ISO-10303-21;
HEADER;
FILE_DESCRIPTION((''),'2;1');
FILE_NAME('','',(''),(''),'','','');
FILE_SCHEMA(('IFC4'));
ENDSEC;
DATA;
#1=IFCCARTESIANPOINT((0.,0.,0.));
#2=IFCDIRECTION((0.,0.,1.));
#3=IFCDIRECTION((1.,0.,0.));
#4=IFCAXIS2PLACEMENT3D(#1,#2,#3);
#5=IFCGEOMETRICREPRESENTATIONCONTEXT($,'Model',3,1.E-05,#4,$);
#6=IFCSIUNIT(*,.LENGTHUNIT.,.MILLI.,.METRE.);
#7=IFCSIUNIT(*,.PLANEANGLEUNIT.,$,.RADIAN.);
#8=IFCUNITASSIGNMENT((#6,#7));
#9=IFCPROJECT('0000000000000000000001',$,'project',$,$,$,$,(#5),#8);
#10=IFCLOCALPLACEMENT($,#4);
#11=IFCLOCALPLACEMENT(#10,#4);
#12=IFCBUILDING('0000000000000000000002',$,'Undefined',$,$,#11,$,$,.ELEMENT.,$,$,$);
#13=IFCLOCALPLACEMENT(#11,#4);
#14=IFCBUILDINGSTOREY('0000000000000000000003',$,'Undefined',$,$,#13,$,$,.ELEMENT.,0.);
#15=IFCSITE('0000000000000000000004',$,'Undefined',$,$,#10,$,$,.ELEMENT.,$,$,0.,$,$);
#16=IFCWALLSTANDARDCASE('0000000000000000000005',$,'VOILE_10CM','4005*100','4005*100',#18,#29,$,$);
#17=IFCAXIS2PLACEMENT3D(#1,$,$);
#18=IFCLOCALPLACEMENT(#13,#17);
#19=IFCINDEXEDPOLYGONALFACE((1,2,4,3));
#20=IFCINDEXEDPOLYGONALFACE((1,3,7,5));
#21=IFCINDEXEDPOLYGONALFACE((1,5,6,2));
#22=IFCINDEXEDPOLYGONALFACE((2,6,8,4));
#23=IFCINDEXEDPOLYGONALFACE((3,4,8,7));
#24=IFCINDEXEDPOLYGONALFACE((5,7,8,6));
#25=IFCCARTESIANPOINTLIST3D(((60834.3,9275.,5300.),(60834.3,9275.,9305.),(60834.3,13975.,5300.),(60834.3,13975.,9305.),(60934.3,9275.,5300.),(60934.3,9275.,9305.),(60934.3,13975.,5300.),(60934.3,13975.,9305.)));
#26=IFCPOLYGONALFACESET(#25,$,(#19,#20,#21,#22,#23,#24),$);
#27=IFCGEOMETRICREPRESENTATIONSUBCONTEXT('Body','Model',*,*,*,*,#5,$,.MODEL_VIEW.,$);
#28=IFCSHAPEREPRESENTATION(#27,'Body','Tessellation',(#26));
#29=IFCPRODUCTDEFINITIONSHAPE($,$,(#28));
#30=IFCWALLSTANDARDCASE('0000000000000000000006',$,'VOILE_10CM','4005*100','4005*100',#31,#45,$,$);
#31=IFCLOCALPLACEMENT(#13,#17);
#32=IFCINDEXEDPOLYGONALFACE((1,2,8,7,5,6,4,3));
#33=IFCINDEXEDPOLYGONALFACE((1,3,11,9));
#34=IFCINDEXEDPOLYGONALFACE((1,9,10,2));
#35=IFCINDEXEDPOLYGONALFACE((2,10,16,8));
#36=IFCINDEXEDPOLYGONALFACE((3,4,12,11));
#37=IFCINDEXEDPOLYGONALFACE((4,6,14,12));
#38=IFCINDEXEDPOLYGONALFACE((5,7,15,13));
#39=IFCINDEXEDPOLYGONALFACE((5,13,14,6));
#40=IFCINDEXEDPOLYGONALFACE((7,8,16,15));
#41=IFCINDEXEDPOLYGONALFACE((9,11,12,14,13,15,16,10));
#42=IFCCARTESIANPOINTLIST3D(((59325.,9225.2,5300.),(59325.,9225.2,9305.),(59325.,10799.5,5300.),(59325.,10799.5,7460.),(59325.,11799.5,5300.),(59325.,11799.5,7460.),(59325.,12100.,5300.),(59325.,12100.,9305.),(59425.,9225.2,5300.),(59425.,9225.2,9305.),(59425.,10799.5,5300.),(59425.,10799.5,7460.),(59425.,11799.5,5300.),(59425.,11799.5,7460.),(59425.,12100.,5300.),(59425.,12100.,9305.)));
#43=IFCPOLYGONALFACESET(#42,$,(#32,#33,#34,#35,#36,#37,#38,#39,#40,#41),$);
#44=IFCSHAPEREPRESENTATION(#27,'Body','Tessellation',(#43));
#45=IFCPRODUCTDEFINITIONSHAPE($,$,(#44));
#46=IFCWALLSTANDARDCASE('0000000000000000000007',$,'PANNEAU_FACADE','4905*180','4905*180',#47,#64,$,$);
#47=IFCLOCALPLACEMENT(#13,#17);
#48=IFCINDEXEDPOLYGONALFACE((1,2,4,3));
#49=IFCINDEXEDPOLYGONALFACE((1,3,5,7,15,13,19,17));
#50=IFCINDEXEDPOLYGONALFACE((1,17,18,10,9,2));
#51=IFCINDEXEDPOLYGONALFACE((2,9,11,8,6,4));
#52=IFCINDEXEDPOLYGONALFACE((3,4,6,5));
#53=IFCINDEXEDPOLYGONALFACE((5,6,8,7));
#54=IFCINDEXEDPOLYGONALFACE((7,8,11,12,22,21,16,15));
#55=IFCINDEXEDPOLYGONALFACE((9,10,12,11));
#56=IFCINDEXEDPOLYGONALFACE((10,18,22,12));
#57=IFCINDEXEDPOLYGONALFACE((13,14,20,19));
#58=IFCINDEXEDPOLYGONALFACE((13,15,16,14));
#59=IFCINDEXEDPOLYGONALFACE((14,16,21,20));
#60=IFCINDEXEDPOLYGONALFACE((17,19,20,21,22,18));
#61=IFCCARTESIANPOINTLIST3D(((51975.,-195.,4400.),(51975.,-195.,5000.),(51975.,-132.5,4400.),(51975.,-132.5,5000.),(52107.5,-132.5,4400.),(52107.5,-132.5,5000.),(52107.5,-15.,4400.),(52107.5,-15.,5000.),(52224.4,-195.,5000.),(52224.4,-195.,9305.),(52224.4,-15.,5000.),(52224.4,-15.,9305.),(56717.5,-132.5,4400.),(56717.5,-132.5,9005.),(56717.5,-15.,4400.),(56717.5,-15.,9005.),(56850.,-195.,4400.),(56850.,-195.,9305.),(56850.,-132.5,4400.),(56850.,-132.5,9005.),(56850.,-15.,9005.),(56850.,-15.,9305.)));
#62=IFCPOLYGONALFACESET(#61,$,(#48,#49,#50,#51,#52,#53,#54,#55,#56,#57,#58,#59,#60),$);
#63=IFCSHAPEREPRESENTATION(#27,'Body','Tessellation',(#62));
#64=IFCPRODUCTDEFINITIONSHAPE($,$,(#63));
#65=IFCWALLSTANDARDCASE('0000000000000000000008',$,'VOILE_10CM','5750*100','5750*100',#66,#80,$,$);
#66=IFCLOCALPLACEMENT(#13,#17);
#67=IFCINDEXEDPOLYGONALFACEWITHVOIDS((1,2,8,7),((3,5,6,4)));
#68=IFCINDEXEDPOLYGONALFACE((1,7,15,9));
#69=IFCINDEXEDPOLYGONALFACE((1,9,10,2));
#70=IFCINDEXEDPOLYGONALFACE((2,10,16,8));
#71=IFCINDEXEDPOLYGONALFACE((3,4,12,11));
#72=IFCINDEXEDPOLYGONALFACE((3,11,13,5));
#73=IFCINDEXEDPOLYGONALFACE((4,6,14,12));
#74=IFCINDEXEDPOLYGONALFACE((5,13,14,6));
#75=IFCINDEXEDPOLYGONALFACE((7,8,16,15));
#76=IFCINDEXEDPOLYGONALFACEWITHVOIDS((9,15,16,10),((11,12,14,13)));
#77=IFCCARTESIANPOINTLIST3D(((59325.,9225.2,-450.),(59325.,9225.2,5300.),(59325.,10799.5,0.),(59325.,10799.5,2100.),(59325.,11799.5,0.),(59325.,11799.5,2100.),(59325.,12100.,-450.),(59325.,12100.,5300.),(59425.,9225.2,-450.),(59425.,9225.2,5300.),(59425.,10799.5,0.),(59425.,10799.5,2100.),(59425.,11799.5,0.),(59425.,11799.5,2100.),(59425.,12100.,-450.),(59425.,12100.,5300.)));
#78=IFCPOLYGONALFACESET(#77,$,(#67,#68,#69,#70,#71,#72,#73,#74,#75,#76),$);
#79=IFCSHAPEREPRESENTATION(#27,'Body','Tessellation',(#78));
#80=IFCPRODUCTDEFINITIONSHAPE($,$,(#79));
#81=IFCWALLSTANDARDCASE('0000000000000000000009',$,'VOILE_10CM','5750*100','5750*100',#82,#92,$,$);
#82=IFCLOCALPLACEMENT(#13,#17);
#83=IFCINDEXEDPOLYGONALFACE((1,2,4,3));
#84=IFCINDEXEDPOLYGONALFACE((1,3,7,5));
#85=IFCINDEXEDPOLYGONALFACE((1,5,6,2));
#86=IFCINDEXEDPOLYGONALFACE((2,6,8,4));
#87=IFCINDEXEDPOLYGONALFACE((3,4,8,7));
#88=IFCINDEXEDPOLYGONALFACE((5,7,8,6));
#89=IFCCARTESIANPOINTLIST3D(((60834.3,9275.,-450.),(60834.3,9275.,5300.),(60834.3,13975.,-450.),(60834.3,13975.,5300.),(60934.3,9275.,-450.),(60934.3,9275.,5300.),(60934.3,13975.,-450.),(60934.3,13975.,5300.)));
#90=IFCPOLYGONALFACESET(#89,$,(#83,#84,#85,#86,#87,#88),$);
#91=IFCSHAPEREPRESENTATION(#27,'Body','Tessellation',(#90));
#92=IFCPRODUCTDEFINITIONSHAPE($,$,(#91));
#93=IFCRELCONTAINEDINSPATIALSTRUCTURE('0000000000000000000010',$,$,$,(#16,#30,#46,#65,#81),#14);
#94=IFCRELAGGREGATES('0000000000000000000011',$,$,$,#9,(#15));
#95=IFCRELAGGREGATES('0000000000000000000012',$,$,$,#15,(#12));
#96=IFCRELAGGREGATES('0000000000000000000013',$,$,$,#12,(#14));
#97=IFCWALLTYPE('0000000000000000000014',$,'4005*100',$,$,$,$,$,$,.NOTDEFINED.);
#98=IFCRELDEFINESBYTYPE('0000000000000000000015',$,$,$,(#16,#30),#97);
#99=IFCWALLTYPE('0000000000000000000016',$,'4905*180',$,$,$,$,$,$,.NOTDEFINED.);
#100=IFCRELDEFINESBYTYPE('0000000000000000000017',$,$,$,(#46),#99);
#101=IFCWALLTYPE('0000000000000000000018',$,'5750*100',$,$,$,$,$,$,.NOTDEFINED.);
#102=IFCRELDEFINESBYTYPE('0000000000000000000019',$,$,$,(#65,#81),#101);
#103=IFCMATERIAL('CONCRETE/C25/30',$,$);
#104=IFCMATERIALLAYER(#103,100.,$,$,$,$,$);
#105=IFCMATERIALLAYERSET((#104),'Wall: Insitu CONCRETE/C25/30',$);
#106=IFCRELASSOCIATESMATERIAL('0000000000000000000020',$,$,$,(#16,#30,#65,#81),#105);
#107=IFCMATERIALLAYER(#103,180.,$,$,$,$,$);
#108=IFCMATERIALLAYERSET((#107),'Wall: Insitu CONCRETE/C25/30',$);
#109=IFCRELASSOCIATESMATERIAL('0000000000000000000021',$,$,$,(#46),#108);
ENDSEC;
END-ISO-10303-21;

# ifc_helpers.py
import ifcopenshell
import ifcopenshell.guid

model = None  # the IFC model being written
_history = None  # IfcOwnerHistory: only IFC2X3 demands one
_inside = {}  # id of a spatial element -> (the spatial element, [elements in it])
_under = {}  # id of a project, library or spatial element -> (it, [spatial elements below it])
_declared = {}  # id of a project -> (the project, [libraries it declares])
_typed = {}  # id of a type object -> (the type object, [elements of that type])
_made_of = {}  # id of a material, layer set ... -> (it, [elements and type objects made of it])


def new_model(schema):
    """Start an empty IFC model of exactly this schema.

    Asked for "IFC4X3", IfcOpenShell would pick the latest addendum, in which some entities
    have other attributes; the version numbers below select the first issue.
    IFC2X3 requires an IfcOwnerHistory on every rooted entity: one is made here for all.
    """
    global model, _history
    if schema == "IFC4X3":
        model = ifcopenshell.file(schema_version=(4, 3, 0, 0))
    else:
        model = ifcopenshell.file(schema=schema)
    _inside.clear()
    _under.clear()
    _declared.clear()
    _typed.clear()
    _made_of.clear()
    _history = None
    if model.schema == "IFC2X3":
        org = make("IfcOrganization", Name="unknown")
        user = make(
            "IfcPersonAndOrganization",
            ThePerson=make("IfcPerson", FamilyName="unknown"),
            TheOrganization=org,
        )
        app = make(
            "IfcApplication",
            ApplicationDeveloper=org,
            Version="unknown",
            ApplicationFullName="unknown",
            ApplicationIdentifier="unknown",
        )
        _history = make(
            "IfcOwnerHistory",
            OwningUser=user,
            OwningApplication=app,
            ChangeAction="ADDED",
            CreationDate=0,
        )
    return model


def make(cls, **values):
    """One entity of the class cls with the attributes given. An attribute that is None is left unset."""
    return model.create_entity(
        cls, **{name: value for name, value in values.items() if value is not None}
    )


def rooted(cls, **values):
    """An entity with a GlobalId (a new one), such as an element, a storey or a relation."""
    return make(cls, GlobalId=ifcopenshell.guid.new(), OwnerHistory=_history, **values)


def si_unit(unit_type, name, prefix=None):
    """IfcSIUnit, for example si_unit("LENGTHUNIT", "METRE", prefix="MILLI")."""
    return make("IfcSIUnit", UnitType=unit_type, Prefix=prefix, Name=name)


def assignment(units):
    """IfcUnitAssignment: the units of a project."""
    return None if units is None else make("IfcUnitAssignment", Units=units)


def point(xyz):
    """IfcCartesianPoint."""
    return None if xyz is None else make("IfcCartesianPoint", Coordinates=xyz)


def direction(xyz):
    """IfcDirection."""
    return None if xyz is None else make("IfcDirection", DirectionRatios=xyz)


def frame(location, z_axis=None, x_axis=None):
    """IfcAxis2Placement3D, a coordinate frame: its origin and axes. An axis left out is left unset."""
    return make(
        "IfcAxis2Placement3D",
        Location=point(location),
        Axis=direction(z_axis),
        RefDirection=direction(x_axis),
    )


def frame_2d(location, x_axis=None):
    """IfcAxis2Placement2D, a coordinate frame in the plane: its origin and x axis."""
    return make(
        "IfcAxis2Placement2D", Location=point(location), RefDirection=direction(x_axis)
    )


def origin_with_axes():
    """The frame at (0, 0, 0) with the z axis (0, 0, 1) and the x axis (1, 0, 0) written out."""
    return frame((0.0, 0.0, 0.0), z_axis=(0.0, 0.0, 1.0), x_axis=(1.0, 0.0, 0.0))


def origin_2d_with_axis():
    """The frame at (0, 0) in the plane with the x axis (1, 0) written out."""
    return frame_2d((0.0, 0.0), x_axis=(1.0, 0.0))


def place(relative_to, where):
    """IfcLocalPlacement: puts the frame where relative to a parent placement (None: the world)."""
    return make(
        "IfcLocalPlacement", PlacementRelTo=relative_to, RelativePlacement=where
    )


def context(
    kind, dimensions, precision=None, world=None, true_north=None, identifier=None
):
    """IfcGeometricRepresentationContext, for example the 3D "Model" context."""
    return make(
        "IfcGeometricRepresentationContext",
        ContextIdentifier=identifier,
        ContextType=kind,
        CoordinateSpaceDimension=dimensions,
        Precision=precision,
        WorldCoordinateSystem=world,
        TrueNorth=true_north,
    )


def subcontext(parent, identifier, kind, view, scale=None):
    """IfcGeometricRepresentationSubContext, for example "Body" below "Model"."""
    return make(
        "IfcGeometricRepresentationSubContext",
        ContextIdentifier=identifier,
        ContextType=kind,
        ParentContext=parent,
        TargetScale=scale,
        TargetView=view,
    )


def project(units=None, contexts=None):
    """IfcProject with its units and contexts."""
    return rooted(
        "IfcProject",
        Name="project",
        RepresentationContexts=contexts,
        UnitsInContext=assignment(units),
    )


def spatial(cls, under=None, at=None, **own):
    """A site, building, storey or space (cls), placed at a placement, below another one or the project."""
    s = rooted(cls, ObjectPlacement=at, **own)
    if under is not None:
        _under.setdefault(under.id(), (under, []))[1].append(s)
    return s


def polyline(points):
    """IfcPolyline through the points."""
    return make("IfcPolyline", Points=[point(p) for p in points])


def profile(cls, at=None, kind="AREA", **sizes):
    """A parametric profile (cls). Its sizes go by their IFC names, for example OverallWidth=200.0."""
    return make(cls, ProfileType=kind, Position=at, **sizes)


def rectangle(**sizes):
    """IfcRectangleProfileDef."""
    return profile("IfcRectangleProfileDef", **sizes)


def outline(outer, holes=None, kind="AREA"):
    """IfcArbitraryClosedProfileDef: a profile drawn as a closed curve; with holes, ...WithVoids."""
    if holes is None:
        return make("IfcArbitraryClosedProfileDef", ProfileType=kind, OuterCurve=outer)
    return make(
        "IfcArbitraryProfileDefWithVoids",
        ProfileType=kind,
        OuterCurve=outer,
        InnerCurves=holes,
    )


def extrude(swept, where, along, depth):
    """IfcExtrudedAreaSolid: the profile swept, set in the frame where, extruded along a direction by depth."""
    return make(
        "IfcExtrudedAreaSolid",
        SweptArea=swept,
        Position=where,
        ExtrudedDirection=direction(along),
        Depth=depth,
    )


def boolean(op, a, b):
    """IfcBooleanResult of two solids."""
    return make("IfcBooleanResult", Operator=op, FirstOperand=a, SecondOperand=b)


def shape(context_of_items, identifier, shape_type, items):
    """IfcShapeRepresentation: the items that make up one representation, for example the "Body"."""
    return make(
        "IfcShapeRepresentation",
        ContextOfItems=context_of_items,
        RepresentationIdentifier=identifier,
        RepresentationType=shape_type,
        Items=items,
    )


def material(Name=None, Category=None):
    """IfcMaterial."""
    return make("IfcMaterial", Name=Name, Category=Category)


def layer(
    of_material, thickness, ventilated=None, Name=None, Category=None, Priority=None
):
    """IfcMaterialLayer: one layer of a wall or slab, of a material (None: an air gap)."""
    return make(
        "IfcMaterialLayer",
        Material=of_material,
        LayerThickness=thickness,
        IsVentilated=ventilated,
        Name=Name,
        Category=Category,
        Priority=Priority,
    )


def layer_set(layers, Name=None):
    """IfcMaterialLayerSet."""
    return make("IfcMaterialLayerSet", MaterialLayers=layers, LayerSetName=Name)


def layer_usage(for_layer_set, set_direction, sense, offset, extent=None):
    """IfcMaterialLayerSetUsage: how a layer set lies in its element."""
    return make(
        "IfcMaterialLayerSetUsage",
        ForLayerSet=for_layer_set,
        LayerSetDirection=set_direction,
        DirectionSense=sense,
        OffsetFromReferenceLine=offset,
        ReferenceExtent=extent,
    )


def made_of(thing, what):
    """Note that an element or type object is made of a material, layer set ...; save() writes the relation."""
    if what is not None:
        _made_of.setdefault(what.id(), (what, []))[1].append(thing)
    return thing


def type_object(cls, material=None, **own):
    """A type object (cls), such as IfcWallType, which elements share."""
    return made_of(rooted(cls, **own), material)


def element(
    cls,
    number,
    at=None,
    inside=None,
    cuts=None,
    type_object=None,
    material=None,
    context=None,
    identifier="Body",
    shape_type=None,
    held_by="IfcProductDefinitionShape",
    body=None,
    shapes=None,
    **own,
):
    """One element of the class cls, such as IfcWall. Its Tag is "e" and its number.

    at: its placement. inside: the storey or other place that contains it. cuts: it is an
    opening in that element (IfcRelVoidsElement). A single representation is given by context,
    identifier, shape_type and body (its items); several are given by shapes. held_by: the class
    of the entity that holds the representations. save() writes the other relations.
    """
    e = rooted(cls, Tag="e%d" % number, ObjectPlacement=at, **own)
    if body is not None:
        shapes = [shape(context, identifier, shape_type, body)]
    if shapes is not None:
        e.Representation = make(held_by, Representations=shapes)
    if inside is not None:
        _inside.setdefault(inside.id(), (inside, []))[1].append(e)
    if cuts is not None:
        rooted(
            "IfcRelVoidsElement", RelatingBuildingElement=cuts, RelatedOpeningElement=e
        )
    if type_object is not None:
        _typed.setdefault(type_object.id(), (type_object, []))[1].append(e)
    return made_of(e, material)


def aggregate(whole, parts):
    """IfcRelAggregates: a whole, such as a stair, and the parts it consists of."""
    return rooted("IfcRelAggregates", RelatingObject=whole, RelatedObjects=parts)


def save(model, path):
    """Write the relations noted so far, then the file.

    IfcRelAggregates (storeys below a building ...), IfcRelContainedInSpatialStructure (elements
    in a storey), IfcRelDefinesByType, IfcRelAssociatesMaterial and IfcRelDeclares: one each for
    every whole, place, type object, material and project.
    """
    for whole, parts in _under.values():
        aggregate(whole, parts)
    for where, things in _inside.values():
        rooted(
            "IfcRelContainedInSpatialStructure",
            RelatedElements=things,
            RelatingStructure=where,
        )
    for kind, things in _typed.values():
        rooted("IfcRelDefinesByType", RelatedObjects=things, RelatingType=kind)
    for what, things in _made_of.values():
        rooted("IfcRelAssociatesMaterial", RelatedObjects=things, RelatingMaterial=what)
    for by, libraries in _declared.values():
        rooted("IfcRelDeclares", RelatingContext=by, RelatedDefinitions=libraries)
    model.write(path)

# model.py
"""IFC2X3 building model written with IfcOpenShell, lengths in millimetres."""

from ifc_helpers import new_model, si_unit, frame, frame_2d, origin_with_axes, origin_2d_with_axis, place, context, subcontext, project, spatial, polyline, rectangle, outline, extrude, boolean, material, layer, layer_set, layer_usage, type_object, element, save


model = new_model("IFC2X3")

# Units and contexts
model_context = context("Model", 3, precision=1e-05, world=origin_with_axes())
body_context = subcontext(model_context, "Body", "Model", "MODEL_VIEW")
ifc_project = project(units=[si_unit("LENGTHUNIT", "METRE", prefix="MILLI"), si_unit("PLANEANGLEUNIT", "RADIAN")], contexts=[model_context])

# Site, building, storey
site_placement = place(None, origin_with_axes())
site = spatial("IfcSite", under=ifc_project, at=site_placement, Name="Undefined", CompositionType="ELEMENT", RefElevation=0.0)
building_placement = place(site_placement, origin_with_axes())
building = spatial("IfcBuilding", under=site, at=building_placement, Name="Undefined", CompositionType="ELEMENT")
storey_placement = place(building_placement, origin_with_axes())
storey = spatial("IfcBuildingStorey", under=building, at=storey_placement, Name="Undefined", CompositionType="ELEMENT", Elevation=0.0)

# Shared definitions
ifc_material_1 = material(Name="CONCRETE/C25/30")

# Walls
ifc_layer_1 = layer(ifc_material_1, 180.0)
ifc_layer_set_1 = layer_set([ifc_layer_1], Name="Wall: Insitu CONCRETE/C25/30")
ifc_layer_2 = layer(ifc_material_1, 100.0)
ifc_layer_set_2 = layer_set([ifc_layer_2], Name="Wall: Insitu CONCRETE/C25/30")
wall_type_1 = type_object("IfcWallType", Name="4005*100", PredefinedType="NOTDEFINED")
ifc_layer_usage_1 = layer_usage(ifc_layer_set_2, "AXIS2", "POSITIVE", -50.0)
wall_1_placement = place(storey_placement, frame((60884.3, 13975.0, 5300.0), z_axis=(0.0, 0.0, 1.0), x_axis=(0.0, -1.0, 0.0)))
element("IfcWallStandardCase", 1, at=wall_1_placement, inside=storey, type_object=wall_type_1, material=ifc_layer_usage_1, Name="VOILE_10CM", Description="4005*100", ObjectType="4005*100", context=body_context, shape_type="SweptSolid", body=[
    extrude(rectangle(XDim=4700.0, YDim=100.0, at=frame_2d((0.0, 2350.0), x_axis=(0.0, -1.0))), frame((0.0, 0.0, 0.0), z_axis=(0.0, 0.0, 1.0), x_axis=(0.0, -1.0, 0.0)), (0.0, 0.0, 1.0), 4005.0),
])
ifc_layer_usage_2 = layer_usage(ifc_layer_set_2, "AXIS2", "POSITIVE", -50.0)
wall_2_placement = place(storey_placement, frame((59375.0, 12100.0, 5300.0), z_axis=(0.0, 0.0, 1.0), x_axis=(0.0, -1.0, 0.0)))
element("IfcWallStandardCase", 2, at=wall_2_placement, inside=storey, type_object=wall_type_1, material=ifc_layer_usage_2, Name="VOILE_10CM", Description="4005*100", ObjectType="4005*100", context=body_context, shape_type="CSG", body=[
    boolean("DIFFERENCE", extrude(rectangle(XDim=2874.8, YDim=100.0, at=frame_2d((0.0, 1437.4), x_axis=(0.0, -1.0))), frame((0.0, 0.0, 0.0), z_axis=(0.0, 0.0, 1.0), x_axis=(0.0, -1.0, 0.0)), (0.0, 0.0, 1.0), 4005.0), extrude(outline(polyline([(0.0, 0.0), (2160.0, 0.0), (2160.0, 1000.0), (0.0, 1000.0), (0.0, 0.0)])), frame((1300.5, -60.0, 2160.0), z_axis=(0.0, 1.0, 0.0), x_axis=(0.0, 0.0, -1.0)), (0.0, 0.0, 1.0), 120.0)),
])
ifc_layer_usage_3 = layer_usage(ifc_layer_set_1, "AXIS2", "POSITIVE", -90.0)
wall_type_2 = type_object("IfcWallType", Name="4905*180", PredefinedType="NOTDEFINED")
wall_3_placement = place(storey_placement, frame((56850.0, -105.0, 4400.0), z_axis=(0.0, 0.0, 1.0), x_axis=(-1.0, 0.0, 0.0)))
element("IfcWallStandardCase", 3, at=wall_3_placement, inside=storey, type_object=wall_type_2, material=ifc_layer_usage_3, Name="PANNEAU_FACADE", Description="4905*180", ObjectType="4905*180", context=body_context, shape_type="CSG", body=[
    boolean("DIFFERENCE", boolean("DIFFERENCE", boolean("DIFFERENCE", extrude(rectangle(XDim=4875.0, YDim=180.0, at=frame_2d((0.0, 2437.5), x_axis=(0.0, -1.0))), frame((0.0, 0.0, 0.0), z_axis=(0.0, 0.0, 1.0), x_axis=(0.0, -1.0, 0.0)), (0.0, 0.0, 1.0), 4905.0), extrude(rectangle(XDim=265.0, YDim=265.0, at=origin_2d_with_axis()), frame((4875.0, -105.0, 4605.0), z_axis=(0.0, 0.0, -1.0), x_axis=(1.0, 0.0, 0.0)), (0.0, 0.0, 1.0), 4605.0)), extrude(rectangle(XDim=265.0, YDim=265.0, at=origin_2d_with_axis()), frame((0.0, -105.0, 4605.0), z_axis=(0.0, 0.0, -1.0), x_axis=(1.0, -0.000081, 0.0)), (0.0, 0.0, 1.0), 4605.0)), extrude(outline(polyline([(0.0, 0.0), (249.4, 0.0), (249.4, 4400.0), (0.0, 4400.0), (0.0, 0.0)])), frame((4875.0, 92.5, 5000.0), z_axis=(0.0, -1.0, 0.0), x_axis=(-1.0, 0.0, -0.000001)), (0.0, 0.0, 1.0), 185.0)),
])
ifc_layer_usage_4 = layer_usage(ifc_layer_set_2, "AXIS2", "POSITIVE", -50.0)
wall_type_3 = type_object("IfcWallType", Name="5750*100", PredefinedType="NOTDEFINED")
wall_4_placement = place(storey_placement, frame((59375.0, 12100.0, -450.0), z_axis=(0.0, 0.0, 1.0), x_axis=(0.0, -1.0, 0.0)))
element("IfcWallStandardCase", 4, at=wall_4_placement, inside=storey, type_object=wall_type_3, material=ifc_layer_usage_4, Name="VOILE_10CM", Description="5750*100", ObjectType="5750*100", context=body_context, shape_type="CSG", body=[
    boolean("DIFFERENCE", extrude(rectangle(XDim=2874.8, YDim=100.0, at=frame_2d((0.0, 1437.4), x_axis=(0.0, -1.0))), frame((0.0, 0.0, 0.0), z_axis=(0.0, 0.0, 1.0), x_axis=(0.0, -1.0, 0.0)), (0.0, 0.0, 1.0), 5750.0), extrude(outline(polyline([(0.0, 0.0), (2100.0, 0.0), (2100.0, 1000.0), (0.0, 1000.0), (0.0, 0.0)])), frame((1300.5, -60.0, 2550.0), z_axis=(0.0, 1.0, 0.0), x_axis=(0.0, 0.0, -1.0)), (0.0, 0.0, 1.0), 120.0)),
])
ifc_layer_usage_5 = layer_usage(ifc_layer_set_2, "AXIS2", "POSITIVE", -50.0)
wall_5_placement = place(storey_placement, frame((60884.3, 13975.0, -450.0), z_axis=(0.0, 0.0, 1.0), x_axis=(0.0, -1.0, 0.0)))
element("IfcWallStandardCase", 5, at=wall_5_placement, inside=storey, type_object=wall_type_3, material=ifc_layer_usage_5, Name="VOILE_10CM", Description="5750*100", ObjectType="5750*100", context=body_context, shape_type="SweptSolid", body=[
    extrude(rectangle(XDim=4700.0, YDim=100.0, at=frame_2d((0.0, 2350.0), x_axis=(0.0, -1.0))), frame((0.0, 0.0, 0.0), z_axis=(0.0, 0.0, 1.0), x_axis=(0.0, -1.0, 0.0)), (0.0, 0.0, 1.0), 5750.0),
])

save(model, "model.ifc")
